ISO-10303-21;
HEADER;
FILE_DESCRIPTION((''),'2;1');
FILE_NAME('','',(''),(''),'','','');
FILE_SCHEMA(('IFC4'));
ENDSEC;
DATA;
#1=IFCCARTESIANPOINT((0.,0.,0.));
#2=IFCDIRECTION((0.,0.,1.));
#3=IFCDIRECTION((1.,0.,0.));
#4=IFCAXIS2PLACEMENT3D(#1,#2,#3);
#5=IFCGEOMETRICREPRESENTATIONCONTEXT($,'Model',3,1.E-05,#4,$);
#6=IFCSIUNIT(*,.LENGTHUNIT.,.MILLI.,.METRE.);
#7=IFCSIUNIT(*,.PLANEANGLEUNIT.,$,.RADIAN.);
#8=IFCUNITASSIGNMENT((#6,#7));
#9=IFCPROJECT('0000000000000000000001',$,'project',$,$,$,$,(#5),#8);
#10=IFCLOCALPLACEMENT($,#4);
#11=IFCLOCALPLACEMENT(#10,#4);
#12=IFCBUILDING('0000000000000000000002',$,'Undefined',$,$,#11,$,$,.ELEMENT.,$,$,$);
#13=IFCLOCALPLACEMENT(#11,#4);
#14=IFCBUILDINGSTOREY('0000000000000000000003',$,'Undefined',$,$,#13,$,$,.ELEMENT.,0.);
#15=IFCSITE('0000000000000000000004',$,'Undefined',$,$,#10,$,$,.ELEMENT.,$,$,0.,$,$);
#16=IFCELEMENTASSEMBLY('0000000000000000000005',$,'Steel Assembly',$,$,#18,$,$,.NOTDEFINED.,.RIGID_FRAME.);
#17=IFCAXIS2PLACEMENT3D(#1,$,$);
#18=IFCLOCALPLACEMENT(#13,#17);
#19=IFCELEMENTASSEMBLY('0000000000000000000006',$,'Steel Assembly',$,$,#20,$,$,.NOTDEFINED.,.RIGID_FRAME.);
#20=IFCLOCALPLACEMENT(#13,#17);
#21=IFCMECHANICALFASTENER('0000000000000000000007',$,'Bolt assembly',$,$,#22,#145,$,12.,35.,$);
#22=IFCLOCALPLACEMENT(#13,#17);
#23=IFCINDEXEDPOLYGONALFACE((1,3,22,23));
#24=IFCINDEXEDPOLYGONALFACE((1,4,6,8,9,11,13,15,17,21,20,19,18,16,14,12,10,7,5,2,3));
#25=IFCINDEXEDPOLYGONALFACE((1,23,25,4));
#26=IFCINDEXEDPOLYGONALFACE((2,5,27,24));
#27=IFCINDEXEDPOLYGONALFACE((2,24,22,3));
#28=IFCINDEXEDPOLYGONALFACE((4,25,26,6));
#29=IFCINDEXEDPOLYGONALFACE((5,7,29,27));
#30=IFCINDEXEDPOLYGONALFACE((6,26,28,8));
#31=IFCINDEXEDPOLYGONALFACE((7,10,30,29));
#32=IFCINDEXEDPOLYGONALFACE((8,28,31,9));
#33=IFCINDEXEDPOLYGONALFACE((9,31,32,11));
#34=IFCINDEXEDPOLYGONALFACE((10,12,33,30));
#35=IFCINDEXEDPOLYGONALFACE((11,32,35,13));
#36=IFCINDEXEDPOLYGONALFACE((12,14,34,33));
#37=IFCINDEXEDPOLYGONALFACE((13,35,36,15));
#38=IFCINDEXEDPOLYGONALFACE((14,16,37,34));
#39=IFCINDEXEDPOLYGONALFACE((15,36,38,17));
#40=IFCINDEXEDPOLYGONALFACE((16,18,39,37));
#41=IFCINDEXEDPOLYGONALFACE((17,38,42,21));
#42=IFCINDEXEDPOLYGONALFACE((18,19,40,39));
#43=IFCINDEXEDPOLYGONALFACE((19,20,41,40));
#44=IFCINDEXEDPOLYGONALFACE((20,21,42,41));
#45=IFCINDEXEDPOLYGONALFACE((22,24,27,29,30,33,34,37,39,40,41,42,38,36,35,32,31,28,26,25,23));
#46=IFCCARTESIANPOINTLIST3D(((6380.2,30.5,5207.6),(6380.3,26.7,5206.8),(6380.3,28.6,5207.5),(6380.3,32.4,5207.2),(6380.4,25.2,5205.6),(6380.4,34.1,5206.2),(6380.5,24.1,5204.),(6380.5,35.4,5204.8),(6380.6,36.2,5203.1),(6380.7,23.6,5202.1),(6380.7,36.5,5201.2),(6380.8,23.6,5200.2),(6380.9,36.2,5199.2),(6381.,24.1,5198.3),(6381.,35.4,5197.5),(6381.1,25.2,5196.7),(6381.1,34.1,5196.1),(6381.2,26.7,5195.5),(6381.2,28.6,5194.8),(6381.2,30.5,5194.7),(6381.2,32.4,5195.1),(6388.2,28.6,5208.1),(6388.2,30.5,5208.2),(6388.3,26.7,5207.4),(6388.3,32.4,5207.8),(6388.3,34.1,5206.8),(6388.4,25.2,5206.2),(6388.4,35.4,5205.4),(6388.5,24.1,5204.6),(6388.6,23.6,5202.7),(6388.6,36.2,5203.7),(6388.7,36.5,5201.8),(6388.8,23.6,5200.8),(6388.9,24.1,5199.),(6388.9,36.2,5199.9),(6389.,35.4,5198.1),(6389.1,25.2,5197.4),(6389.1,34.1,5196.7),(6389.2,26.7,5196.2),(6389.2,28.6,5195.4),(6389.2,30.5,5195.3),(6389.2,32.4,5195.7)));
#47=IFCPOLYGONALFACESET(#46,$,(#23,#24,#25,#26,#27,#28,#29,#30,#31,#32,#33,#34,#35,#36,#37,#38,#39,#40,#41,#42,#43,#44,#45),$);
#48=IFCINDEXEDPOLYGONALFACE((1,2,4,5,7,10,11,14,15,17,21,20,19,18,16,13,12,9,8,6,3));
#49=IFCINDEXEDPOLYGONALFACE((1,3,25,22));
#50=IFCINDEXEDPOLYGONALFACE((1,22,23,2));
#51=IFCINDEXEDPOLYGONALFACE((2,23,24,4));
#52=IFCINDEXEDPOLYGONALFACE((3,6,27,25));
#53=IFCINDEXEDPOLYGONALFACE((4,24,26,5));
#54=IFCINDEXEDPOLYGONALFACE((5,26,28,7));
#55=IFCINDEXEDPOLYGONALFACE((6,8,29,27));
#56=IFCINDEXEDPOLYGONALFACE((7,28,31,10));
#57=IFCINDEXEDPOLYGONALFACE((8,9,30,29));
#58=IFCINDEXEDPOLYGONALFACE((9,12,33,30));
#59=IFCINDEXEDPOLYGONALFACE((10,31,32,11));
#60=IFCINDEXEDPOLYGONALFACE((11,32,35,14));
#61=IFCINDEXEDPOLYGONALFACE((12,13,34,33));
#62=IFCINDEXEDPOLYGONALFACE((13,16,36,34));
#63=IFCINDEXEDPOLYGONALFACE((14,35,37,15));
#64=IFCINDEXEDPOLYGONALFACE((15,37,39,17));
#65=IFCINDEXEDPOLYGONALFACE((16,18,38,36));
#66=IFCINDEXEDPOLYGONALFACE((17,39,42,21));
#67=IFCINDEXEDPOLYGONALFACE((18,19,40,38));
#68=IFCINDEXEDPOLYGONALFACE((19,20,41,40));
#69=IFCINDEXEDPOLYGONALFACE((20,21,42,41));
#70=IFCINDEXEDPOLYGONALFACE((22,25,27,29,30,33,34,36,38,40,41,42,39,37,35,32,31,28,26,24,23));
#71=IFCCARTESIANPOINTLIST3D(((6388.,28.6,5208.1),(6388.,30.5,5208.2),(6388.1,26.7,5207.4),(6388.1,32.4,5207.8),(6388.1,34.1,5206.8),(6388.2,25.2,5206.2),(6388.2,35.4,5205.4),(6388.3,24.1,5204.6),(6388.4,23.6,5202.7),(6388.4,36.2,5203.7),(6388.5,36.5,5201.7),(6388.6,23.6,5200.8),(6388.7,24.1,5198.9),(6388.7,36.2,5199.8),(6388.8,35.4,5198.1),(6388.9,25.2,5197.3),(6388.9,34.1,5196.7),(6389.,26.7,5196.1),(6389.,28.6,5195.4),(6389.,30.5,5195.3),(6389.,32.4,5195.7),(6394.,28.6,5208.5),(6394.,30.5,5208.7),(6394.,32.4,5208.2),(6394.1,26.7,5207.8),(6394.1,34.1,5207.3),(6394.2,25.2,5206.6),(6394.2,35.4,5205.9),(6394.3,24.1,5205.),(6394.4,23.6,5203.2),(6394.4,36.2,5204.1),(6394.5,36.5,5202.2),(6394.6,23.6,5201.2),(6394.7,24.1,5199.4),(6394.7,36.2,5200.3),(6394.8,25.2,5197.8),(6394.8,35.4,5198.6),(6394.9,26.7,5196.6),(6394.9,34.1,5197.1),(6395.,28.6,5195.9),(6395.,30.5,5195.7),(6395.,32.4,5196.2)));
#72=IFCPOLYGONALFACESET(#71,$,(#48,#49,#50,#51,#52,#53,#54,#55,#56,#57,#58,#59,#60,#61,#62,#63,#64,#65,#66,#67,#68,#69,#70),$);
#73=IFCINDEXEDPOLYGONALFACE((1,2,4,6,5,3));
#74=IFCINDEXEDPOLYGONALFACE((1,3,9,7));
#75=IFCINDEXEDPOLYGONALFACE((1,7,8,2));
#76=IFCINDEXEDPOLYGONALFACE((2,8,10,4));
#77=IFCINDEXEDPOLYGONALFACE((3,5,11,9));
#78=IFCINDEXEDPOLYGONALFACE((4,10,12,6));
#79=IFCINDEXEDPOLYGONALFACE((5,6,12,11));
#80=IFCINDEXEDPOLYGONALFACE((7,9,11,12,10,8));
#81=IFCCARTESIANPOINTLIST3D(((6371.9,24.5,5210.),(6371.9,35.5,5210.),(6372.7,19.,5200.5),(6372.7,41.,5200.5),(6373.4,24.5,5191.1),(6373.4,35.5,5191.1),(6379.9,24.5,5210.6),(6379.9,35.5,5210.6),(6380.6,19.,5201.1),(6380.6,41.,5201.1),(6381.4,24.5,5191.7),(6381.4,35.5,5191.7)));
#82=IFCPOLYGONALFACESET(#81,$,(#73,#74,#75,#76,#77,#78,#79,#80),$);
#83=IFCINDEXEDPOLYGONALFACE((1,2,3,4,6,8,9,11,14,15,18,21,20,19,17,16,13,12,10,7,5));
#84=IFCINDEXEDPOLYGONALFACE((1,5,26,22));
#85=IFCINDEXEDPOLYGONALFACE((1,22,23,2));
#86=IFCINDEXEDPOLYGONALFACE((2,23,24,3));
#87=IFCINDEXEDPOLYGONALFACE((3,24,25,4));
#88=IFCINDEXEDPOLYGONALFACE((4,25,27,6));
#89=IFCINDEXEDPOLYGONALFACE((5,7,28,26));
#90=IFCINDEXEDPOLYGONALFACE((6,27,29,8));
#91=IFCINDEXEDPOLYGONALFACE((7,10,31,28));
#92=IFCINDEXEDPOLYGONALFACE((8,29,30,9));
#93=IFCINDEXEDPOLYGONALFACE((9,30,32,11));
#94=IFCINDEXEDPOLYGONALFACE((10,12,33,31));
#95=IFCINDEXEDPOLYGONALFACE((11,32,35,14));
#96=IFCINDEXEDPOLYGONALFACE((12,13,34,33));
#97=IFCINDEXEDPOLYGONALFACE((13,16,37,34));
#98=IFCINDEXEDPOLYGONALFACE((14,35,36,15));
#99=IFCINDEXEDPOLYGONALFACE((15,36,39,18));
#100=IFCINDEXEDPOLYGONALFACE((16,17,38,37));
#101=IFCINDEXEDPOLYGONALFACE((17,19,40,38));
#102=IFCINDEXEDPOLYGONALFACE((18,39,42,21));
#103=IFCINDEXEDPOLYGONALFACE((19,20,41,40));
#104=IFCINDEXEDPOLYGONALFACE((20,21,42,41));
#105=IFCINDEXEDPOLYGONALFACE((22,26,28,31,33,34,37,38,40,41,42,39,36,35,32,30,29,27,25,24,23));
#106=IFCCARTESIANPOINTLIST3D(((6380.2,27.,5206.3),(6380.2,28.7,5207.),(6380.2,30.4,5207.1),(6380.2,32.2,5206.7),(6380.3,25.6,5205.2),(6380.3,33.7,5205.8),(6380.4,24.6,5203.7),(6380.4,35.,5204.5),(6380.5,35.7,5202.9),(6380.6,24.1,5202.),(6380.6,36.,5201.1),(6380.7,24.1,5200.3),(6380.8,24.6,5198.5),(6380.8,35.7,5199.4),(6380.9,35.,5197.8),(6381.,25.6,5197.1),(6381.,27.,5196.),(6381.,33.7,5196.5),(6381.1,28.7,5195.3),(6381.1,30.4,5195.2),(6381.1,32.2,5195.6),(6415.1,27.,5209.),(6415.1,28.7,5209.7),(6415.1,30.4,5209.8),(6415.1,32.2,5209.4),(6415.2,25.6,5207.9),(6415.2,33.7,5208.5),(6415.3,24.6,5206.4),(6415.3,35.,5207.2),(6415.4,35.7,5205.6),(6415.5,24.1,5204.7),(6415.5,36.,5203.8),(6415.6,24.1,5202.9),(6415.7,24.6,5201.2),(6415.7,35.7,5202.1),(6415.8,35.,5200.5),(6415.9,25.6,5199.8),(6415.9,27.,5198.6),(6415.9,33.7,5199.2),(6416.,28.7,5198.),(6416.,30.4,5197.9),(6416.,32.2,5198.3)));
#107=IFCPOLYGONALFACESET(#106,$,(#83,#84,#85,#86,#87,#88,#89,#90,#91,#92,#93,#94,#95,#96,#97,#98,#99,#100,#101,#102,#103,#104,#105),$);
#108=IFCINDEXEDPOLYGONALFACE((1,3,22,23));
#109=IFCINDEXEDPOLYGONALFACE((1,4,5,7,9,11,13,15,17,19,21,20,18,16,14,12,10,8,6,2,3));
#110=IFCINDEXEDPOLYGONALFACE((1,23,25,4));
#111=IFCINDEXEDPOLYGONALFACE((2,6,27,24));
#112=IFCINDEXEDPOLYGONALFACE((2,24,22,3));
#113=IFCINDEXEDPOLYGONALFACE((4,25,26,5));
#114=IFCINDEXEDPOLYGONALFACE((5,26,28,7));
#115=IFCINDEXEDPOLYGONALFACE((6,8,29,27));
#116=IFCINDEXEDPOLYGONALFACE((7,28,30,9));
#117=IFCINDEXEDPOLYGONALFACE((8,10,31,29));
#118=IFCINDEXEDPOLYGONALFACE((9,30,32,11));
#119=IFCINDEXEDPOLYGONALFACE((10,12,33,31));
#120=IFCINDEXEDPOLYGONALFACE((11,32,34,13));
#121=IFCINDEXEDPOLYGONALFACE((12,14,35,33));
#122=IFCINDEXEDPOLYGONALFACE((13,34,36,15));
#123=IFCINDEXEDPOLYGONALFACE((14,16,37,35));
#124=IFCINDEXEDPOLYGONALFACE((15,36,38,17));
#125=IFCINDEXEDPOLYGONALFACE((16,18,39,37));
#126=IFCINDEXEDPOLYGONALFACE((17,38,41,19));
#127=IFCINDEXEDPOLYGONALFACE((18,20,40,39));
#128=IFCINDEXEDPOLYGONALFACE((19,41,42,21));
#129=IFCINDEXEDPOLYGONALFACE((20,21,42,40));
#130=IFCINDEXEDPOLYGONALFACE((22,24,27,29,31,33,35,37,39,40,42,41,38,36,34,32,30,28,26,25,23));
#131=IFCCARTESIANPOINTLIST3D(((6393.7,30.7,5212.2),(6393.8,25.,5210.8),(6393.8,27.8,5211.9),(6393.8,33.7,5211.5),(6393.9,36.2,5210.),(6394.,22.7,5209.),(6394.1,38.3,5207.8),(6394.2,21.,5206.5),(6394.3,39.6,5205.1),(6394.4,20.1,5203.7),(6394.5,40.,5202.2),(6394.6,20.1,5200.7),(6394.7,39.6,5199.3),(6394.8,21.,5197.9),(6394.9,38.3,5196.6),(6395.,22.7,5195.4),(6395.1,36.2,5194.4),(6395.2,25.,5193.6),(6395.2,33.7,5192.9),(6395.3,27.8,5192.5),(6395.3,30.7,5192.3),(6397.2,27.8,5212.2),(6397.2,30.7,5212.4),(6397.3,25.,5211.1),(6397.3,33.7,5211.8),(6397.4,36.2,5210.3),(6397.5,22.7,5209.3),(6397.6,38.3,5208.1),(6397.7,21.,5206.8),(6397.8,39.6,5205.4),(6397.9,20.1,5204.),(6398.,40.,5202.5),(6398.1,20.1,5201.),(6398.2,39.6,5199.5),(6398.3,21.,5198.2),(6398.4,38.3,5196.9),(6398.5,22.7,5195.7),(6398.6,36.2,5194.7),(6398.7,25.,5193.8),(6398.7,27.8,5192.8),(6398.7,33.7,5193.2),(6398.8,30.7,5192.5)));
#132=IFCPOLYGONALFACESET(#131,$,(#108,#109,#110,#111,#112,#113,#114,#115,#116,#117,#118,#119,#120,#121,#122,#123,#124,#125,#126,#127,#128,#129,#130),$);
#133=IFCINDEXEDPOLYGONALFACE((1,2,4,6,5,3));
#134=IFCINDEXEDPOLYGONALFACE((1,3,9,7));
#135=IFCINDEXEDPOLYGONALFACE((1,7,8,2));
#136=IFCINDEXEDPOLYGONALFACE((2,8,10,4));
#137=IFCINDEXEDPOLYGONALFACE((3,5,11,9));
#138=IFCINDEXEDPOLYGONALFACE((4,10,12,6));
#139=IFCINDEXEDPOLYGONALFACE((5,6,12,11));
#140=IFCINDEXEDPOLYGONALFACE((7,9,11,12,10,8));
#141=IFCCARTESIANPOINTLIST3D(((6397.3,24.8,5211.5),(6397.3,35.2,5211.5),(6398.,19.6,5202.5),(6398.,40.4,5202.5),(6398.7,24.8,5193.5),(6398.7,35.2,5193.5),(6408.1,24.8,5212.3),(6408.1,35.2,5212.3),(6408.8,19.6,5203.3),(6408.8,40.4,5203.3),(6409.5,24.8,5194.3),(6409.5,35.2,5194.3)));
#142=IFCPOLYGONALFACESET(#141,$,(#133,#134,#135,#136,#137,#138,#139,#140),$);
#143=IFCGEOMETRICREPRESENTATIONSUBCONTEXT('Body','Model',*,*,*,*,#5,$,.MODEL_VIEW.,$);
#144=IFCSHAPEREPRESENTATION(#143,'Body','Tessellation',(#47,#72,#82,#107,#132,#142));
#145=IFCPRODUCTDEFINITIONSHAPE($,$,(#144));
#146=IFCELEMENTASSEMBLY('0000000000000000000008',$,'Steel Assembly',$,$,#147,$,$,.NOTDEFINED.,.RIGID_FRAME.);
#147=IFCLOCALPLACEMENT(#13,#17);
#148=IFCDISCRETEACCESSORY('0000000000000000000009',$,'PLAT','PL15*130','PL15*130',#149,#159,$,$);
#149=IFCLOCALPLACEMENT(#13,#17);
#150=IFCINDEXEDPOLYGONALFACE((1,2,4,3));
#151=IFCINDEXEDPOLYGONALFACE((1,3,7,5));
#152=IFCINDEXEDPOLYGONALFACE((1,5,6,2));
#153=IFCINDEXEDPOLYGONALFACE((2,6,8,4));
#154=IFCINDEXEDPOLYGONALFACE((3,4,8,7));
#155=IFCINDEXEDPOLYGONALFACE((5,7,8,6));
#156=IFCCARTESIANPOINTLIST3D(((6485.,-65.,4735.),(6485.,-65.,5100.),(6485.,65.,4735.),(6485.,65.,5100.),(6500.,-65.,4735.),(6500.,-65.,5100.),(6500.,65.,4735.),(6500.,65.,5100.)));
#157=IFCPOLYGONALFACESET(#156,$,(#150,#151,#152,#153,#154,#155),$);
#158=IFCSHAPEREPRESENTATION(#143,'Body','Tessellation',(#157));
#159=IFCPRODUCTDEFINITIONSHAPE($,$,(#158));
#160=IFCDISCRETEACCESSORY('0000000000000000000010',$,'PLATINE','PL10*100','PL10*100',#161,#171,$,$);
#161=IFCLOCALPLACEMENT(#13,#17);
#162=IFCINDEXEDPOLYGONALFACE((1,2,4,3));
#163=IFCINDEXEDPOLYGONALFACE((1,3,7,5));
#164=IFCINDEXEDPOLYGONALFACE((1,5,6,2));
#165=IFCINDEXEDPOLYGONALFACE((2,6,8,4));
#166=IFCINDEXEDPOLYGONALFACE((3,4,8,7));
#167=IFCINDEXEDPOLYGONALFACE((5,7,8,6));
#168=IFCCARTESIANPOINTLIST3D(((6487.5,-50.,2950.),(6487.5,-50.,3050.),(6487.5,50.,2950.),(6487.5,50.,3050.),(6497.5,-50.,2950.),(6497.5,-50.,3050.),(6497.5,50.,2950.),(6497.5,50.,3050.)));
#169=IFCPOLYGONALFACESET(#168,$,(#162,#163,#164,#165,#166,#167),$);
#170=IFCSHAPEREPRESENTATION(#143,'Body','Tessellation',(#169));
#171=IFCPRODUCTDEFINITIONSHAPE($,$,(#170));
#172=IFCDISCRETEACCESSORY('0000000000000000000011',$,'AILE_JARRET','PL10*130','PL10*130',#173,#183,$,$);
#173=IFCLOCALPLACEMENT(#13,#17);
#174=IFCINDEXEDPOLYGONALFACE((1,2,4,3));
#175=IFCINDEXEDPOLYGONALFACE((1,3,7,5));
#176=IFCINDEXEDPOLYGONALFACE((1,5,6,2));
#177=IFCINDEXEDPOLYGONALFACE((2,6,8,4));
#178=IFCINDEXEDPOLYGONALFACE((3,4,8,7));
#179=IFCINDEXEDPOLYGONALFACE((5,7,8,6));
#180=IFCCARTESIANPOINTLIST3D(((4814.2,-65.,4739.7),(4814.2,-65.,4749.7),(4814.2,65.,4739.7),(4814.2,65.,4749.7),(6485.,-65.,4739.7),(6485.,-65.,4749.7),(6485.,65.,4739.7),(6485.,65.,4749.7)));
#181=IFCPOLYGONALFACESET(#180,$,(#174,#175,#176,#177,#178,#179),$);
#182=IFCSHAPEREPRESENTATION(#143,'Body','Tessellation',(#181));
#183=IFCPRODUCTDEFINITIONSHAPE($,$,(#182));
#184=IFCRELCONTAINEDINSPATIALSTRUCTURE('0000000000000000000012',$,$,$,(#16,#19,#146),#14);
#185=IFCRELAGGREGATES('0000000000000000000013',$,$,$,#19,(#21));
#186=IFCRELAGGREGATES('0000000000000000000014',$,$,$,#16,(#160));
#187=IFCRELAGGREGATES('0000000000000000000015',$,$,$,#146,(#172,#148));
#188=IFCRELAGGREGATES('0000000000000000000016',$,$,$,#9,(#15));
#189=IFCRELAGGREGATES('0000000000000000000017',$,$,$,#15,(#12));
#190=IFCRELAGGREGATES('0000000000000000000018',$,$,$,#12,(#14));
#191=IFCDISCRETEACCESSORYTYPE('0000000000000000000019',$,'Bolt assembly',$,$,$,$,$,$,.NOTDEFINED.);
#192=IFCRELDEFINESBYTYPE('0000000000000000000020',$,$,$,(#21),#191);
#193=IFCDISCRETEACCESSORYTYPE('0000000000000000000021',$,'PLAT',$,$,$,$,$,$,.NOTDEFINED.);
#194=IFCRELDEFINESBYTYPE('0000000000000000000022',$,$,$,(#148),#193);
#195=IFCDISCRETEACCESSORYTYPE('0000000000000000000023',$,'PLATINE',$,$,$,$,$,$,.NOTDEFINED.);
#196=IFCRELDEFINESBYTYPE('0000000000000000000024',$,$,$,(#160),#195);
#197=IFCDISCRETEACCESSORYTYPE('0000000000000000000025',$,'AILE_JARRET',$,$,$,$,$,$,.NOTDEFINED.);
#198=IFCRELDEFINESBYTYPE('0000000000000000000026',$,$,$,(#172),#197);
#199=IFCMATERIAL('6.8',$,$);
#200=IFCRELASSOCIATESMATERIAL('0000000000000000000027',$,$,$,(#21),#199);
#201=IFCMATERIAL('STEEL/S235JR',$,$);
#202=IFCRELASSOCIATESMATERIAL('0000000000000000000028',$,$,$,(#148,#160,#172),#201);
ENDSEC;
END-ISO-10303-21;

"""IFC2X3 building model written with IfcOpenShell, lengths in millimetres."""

from ifc_helpers import new_model, si_unit, frame, origin_with_axes, origin_2d_with_axis, place, context, subcontext, project, spatial, polyline, circle, outline, extrude, source, transform, mapped, material, type_object, element, aggregate, save


model = new_model("IFC2X3")

# Units and contexts
model_context = context("Model", 3, precision=1e-05, world=origin_with_axes())
body_context = subcontext(model_context, "Body", "Model", "MODEL_VIEW")
ifc_project = project(units=[si_unit("LENGTHUNIT", "METRE", prefix="MILLI"), si_unit("PLANEANGLEUNIT", "RADIAN")], contexts=[model_context])

# Site, building, storey
site_placement = place(None, origin_with_axes())
site = spatial("IfcSite", under=ifc_project, at=site_placement, Name="Undefined", CompositionType="ELEMENT", RefElevation=0.0)
building_placement = place(site_placement, origin_with_axes())
building = spatial("IfcBuilding", under=site, at=building_placement, Name="Undefined", CompositionType="ELEMENT")
storey_placement = place(building_placement, origin_with_axes())
storey = spatial("IfcBuildingStorey", under=building, at=storey_placement, Name="Undefined", CompositionType="ELEMENT", Elevation=0.0)

# Element assembly
ifc_material_1 = material(Name="STEEL/S235JR")
assembly_1_placement = place(storey_placement, origin_with_axes())
assembly_1 = element("IfcElementAssembly", 1, at=assembly_1_placement, inside=storey, Name="Steel Assembly", AssemblyPlace="NOTDEFINED", PredefinedType="RIGID_FRAME")

# Element assembly, mechanical fastener
ifc_material_2 = material(Name="6.8")
discrete_accessory_type_1 = type_object("IfcDiscreteAccessoryType", Name="Bolt assembly")
shared_shape_1 = source(origin_with_axes(), body_context, "Body", "SweptSolid", [
    extrude(circle(Radius=6.5, at=origin_2d_with_axis()), frame((0.0, -10.9, 0.0), z_axis=(0.0, 1.0, 0.0), x_axis=(1.0, 0.0, 0.0)), (0.0, 0.0, 1.0), 8.0),
    extrude(circle(Radius=6.5, at=origin_2d_with_axis()), frame((0.0, -3.1, 0.0), z_axis=(0.0, 1.0, 0.0), x_axis=(1.0, 0.0, 0.0)), (0.0, 0.0, 1.0), 6.0),
    extrude(outline(polyline([(11.0, 0.0), (5.5, 9.5), (-5.5, 9.5), (-11.0, 0.0), (-5.5, -9.5), (5.5, -9.5), (11.0, 0.0)])), frame((0.0, -19.0, 0.0), z_axis=(0.0, 1.0, 0.0), x_axis=(1.0, 0.0, 0.0)), (0.0, 0.0, 1.0), 8.0),
    extrude(circle(Radius=6.0, at=origin_2d_with_axis()), frame((0.0, -11.0, 0.0), z_axis=(0.0, 1.0, 0.0), x_axis=(1.0, 0.0, 0.0)), (0.0, 0.0, 1.0), 35.0),
    extrude(circle(Radius=10.0, at=origin_2d_with_axis()), frame((0.0, 3.0, 0.0), z_axis=(0.0, 1.0, 0.0), x_axis=(1.0, 0.0, 0.0)), (0.0, 0.0, 1.0), 3.5),
    extrude(outline(polyline([(10.4, 0.0), (5.2, 9.0), (-5.2, 9.0), (-10.4, 0.0), (-5.2, -9.0), (5.2, -9.0), (10.4, 0.0)])), frame((0.0, 6.5, 0.0), z_axis=(0.0, 1.0, 0.0), x_axis=(1.0, 0.0, 0.0)), (0.0, 0.0, 1.0), 10.8),
])
assembly_2_placement = place(storey_placement, origin_with_axes())
assembly_2 = element("IfcElementAssembly", 2, at=assembly_2_placement, inside=storey, Name="Steel Assembly", AssemblyPlace="NOTDEFINED", PredefinedType="RIGID_FRAME")
mechanical_fastener_1_placement = place(assembly_2_placement, frame((6391.6, 30.0, 5202.0), z_axis=(0.076696, 0.0, -0.997054), x_axis=(0.0, 1.0, 0.0)))
mechanical_fastener_1 = element("IfcMechanicalFastener", 3, at=mechanical_fastener_1_placement, type_object=discrete_accessory_type_1, material=ifc_material_2, Name="Bolt assembly", NominalDiameter=12.0, NominalLength=35.0, context=body_context, shape_type="MappedRepresentation", body=[
    mapped(shared_shape_1, transform((0.0, 0.0, 0.0))),
])
aggregate(assembly_2, [mechanical_fastener_1])

# Element assembly, discrete accessory
assembly_3_placement = place(storey_placement, origin_with_axes())
assembly_3 = element("IfcElementAssembly", 4, at=assembly_3_placement, inside=storey, Name="Steel Assembly", AssemblyPlace="NOTDEFINED", PredefinedType="RIGID_FRAME")
discrete_accessory_type_2 = type_object("IfcDiscreteAccessoryType", Name="PLAT")
discrete_accessory_1_placement = place(assembly_3_placement, frame((6492.5, 0.0, 5100.0), z_axis=(-1.0, 0.0, 0.0), x_axis=(0.0, 0.0, -1.0)))
discrete_accessory_1 = element("IfcDiscreteAccessory", 5, at=discrete_accessory_1_placement, type_object=discrete_accessory_type_2, material=ifc_material_1, Name="PLAT", Description="PL15*130", ObjectType="PL15*130", context=body_context, shape_type="SweptSolid", body=[
    extrude(outline(polyline([(365.0, 65.0), (365.0, -65.0), (0.0, -65.0), (0.0, 65.0), (365.0, 65.0)])), frame((0.0, 0.0, -7.5), z_axis=(0.0, 0.0, 1.0), x_axis=(1.0, 0.0, 0.0)), (0.0, 0.0, 1.0), 15.0),
])

# Discrete accessory
discrete_accessory_type_3 = type_object("IfcDiscreteAccessoryType", Name="PLATINE")
discrete_accessory_2_placement = place(assembly_1_placement, frame((6492.5, 0.0, 2950.0), z_axis=(-1.0, 0.0, 0.0), x_axis=(0.0, 0.0, 1.0)))
discrete_accessory_2 = element("IfcDiscreteAccessory", 6, at=discrete_accessory_2_placement, type_object=discrete_accessory_type_3, material=ifc_material_1, Name="PLATINE", Description="PL10*100", ObjectType="PL10*100", context=body_context, shape_type="SweptSolid", body=[
    extrude(outline(polyline([(0.0, -50.0), (0.0, 50.0), (100.0, 50.0), (100.0, -50.0), (0.0, -50.0)])), frame((0.0, 0.0, -5.0), z_axis=(0.0, 0.0, 1.0), x_axis=(1.0, 0.0, 0.0)), (0.0, 0.0, 1.0), 10.0),
])

aggregate(assembly_1, [discrete_accessory_2])

# Discrete accessory
discrete_accessory_type_4 = type_object("IfcDiscreteAccessoryType", Name="AILE_JARRET")
discrete_accessory_3_placement = place(assembly_3_placement, frame((4814.2, 0.0, 4744.7), z_axis=(0.0, 0.0, -1.0), x_axis=(1.0, 0.0, 0.0)))
discrete_accessory_3 = element("IfcDiscreteAccessory", 7, at=discrete_accessory_3_placement, type_object=discrete_accessory_type_4, material=ifc_material_1, Name="AILE_JARRET", Description="PL10*130", ObjectType="PL10*130", context=body_context, shape_type="SweptSolid", body=[
    extrude(outline(polyline([(0.0, 65.0), (1670.8, 65.0), (1670.8, -65.0), (0.0, -65.0), (0.0, 65.0)])), frame((0.0, 0.0, -5.0), z_axis=(0.0, 0.0, 1.0), x_axis=(1.0, 0.0, 0.0)), (0.0, 0.0, 1.0), 10.0),
])
aggregate(assembly_3, [discrete_accessory_3, discrete_accessory_1])

save(model, "model.ifc")
